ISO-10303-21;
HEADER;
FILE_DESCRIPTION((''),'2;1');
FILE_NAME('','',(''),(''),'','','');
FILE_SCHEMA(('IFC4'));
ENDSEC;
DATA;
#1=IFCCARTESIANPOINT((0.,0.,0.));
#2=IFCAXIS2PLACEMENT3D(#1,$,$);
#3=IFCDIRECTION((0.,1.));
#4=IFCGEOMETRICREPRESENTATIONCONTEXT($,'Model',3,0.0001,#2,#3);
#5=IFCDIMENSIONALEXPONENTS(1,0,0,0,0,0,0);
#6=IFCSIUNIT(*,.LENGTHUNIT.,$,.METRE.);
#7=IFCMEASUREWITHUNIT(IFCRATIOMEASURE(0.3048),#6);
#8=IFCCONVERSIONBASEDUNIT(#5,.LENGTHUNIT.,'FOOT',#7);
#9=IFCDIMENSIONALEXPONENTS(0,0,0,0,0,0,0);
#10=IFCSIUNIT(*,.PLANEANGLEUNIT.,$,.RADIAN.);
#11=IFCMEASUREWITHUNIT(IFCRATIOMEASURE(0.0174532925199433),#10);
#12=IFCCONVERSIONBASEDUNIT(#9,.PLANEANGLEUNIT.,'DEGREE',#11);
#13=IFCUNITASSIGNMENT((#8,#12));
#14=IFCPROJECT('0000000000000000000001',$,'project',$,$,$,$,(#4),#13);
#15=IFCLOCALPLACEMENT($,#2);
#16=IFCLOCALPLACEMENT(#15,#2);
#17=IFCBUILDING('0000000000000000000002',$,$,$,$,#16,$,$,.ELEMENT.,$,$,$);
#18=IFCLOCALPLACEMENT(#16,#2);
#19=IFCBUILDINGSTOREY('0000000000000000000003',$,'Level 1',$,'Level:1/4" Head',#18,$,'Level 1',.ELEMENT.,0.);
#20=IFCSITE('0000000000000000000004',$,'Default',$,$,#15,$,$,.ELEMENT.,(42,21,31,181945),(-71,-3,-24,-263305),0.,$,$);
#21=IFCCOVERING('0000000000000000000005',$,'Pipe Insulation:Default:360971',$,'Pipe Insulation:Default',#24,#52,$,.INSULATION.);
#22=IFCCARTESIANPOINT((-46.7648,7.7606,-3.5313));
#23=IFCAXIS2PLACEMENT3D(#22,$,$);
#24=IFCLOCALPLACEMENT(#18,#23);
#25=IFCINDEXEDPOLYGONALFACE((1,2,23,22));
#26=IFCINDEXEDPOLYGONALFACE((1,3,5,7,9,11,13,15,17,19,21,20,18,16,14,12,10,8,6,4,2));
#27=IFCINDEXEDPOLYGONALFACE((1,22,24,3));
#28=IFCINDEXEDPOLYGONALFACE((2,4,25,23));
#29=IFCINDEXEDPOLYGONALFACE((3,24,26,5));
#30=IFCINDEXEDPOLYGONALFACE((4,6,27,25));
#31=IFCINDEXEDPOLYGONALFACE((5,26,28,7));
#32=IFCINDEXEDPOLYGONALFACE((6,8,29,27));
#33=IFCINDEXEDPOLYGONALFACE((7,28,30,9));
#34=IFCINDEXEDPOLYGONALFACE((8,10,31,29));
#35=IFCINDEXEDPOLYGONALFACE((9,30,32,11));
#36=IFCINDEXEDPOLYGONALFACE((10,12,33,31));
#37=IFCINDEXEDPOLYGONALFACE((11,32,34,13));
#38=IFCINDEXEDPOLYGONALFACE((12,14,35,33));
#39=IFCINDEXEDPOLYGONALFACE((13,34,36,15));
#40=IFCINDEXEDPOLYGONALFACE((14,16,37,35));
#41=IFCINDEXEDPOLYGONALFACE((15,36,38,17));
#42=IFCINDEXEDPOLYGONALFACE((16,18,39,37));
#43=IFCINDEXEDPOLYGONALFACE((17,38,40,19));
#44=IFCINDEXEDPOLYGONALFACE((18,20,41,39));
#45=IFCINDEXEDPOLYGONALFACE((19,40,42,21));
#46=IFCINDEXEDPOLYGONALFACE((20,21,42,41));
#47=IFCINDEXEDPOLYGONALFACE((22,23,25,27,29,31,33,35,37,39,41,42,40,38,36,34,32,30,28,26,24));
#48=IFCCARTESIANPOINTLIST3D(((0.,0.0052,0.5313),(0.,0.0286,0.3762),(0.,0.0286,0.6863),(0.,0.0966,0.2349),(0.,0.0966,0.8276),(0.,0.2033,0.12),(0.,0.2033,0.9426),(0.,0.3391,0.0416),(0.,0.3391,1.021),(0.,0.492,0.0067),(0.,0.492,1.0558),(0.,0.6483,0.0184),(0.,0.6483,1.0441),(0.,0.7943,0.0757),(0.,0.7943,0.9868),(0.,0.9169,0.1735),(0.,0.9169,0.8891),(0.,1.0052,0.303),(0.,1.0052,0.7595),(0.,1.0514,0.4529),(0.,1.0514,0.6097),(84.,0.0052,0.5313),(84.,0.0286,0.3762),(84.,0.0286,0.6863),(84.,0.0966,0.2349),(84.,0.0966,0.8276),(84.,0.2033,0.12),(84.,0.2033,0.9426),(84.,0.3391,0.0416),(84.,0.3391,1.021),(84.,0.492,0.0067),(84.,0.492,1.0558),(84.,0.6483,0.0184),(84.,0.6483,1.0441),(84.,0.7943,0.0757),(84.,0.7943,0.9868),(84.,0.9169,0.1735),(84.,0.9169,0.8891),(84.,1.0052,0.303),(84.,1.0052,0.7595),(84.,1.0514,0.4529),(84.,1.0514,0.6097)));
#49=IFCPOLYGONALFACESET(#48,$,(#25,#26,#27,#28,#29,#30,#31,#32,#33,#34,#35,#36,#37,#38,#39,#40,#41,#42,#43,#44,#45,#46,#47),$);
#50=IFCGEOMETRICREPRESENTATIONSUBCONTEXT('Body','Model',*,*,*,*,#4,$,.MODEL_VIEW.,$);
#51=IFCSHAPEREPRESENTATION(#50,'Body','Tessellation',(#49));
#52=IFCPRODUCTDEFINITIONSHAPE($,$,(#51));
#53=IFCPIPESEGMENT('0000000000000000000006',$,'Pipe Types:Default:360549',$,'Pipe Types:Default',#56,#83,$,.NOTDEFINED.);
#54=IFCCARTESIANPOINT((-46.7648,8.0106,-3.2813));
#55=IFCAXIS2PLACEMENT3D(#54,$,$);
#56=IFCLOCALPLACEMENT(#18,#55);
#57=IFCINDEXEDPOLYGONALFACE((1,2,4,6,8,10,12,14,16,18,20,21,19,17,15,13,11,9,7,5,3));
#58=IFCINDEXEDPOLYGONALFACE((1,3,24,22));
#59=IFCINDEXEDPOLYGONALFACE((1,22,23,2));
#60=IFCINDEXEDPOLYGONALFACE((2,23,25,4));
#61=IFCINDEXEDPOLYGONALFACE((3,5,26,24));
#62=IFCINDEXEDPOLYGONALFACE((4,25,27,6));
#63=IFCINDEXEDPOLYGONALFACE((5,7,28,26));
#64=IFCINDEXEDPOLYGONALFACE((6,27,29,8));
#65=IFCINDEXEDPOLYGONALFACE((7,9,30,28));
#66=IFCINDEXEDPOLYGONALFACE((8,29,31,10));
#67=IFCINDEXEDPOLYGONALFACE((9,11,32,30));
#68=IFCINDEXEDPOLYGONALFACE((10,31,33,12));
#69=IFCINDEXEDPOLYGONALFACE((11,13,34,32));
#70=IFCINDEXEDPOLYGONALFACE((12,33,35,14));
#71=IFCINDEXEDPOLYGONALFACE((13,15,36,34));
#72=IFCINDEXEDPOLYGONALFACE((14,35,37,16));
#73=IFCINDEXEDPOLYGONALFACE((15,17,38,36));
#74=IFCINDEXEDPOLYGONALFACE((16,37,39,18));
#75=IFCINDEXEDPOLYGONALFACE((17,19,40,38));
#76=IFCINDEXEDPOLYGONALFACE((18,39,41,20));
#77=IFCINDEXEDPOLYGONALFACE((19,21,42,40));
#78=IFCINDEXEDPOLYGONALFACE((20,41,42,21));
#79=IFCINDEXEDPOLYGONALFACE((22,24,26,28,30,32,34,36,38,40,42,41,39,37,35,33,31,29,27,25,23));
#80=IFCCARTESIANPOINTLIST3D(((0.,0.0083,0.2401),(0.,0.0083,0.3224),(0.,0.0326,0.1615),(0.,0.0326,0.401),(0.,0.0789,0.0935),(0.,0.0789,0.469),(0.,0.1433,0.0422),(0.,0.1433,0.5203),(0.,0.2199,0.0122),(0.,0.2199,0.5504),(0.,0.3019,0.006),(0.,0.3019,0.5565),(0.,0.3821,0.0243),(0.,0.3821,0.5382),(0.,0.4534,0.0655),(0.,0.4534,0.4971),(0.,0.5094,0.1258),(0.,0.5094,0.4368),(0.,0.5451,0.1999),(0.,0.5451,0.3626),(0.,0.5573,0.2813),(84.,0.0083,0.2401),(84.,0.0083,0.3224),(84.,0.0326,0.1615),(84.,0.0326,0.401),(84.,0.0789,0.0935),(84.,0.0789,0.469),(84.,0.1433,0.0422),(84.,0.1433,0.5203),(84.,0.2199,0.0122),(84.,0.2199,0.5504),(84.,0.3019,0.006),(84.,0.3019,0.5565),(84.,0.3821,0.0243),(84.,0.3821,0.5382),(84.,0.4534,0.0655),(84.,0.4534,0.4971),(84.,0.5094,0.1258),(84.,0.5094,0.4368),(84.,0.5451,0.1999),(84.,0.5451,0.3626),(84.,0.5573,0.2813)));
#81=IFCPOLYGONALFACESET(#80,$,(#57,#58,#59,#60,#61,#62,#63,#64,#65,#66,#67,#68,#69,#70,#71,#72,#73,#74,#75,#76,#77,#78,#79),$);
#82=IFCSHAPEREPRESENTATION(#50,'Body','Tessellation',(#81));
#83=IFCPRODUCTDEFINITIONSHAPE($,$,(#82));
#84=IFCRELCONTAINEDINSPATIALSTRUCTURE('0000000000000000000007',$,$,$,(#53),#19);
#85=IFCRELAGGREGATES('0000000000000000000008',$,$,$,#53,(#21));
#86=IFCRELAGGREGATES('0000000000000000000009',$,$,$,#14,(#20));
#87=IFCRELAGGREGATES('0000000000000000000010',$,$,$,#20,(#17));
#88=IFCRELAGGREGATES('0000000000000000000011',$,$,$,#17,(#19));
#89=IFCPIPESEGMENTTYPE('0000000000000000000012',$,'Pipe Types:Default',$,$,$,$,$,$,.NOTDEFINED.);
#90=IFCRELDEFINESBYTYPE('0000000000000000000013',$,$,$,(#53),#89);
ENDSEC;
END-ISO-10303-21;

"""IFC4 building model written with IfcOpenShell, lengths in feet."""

from ifc_helpers import new_model, entity, si_unit, converted_unit, direction, frame, frame_2d, origin, place, context, subcontext, project, spatial, circle, extrude, type_object, element, aggregate, save


model = new_model("IFC4")

# Units and contexts
model_context = context("Model", 3, precision=0.0001, world=origin(), true_north=direction((0.0, 1.0)))
body_context = subcontext(model_context, "Body", "Model", "MODEL_VIEW")
ifc_project = project(units=[converted_unit("LENGTHUNIT", "FOOT", entity("IfcRatioMeasure", 0.3048), si_unit("LENGTHUNIT", "METRE"), dimensions=[1, 0, 0, 0, 0, 0, 0]), converted_unit("PLANEANGLEUNIT", "DEGREE", entity("IfcRatioMeasure", 0.0174532925199433), si_unit("PLANEANGLEUNIT", "RADIAN"), dimensions=[0, 0, 0, 0, 0, 0, 0])], contexts=[model_context])

# Site, building, storey
site_placement = place(None, origin())
site = spatial("IfcSite", under=ifc_project, at=site_placement, Name="Default", CompositionType="ELEMENT", RefLatitude=(42, 21, 31, 181945), RefLongitude=(-71, -3, -24, -263305), RefElevation=0.0)
building_placement = place(site_placement, origin())
building = spatial("IfcBuilding", under=site, at=building_placement, CompositionType="ELEMENT")
storey_placement = place(building_placement, origin())
storey = spatial("IfcBuildingStorey", under=building, at=storey_placement, Name="Level 1", ObjectType="Level:1/4\" Head", LongName="Level 1", CompositionType="ELEMENT", Elevation=0.0)

# Covering
covering_placement = place(storey_placement, frame((-46.7648, 7.7606, -3.5313)))
covering = element("IfcCovering", 1, at=covering_placement, Name="Pipe Insulation:Default:360971", ObjectType="Pipe Insulation:Default", PredefinedType="INSULATION", context=body_context, shape_type="SweptSolid", body=[
    extrude(circle(Radius=0.526, at=frame_2d((0.0, 0.0), x_axis=(1.0, 0.0))), frame((0.0, 0.5313, 0.5313), z_axis=(1.0, 0.0, 0.0), x_axis=(0.0, -1.0, 0.0)), (0.0, 0.0, 1.0), 84.0),
])

# Pipe segment
pipe_segment_type = type_object("IfcPipeSegmentType", Name="Pipe Types:Default", PredefinedType="NOTDEFINED")
pipe_segment_placement = place(storey_placement, frame((-46.7648, 8.0106, -3.2813)))
pipe_segment = element("IfcPipeSegment", 2, at=pipe_segment_placement, inside=storey, type_object=pipe_segment_type, Name="Pipe Types:Default:360549", ObjectType="Pipe Types:Default", PredefinedType="NOTDEFINED", context=body_context, shape_type="SweptSolid", body=[
    extrude(circle(Radius=0.276, at=frame_2d((0.0, 0.0), x_axis=(1.0, 0.0))), frame((0.0, 0.2813, 0.2813), z_axis=(1.0, 0.0, 0.0), x_axis=(0.0, 1.0, 0.0)), (0.0, 0.0, 1.0), 84.0),
])
aggregate(pipe_segment, [covering])

save(model, "model.ifc")
